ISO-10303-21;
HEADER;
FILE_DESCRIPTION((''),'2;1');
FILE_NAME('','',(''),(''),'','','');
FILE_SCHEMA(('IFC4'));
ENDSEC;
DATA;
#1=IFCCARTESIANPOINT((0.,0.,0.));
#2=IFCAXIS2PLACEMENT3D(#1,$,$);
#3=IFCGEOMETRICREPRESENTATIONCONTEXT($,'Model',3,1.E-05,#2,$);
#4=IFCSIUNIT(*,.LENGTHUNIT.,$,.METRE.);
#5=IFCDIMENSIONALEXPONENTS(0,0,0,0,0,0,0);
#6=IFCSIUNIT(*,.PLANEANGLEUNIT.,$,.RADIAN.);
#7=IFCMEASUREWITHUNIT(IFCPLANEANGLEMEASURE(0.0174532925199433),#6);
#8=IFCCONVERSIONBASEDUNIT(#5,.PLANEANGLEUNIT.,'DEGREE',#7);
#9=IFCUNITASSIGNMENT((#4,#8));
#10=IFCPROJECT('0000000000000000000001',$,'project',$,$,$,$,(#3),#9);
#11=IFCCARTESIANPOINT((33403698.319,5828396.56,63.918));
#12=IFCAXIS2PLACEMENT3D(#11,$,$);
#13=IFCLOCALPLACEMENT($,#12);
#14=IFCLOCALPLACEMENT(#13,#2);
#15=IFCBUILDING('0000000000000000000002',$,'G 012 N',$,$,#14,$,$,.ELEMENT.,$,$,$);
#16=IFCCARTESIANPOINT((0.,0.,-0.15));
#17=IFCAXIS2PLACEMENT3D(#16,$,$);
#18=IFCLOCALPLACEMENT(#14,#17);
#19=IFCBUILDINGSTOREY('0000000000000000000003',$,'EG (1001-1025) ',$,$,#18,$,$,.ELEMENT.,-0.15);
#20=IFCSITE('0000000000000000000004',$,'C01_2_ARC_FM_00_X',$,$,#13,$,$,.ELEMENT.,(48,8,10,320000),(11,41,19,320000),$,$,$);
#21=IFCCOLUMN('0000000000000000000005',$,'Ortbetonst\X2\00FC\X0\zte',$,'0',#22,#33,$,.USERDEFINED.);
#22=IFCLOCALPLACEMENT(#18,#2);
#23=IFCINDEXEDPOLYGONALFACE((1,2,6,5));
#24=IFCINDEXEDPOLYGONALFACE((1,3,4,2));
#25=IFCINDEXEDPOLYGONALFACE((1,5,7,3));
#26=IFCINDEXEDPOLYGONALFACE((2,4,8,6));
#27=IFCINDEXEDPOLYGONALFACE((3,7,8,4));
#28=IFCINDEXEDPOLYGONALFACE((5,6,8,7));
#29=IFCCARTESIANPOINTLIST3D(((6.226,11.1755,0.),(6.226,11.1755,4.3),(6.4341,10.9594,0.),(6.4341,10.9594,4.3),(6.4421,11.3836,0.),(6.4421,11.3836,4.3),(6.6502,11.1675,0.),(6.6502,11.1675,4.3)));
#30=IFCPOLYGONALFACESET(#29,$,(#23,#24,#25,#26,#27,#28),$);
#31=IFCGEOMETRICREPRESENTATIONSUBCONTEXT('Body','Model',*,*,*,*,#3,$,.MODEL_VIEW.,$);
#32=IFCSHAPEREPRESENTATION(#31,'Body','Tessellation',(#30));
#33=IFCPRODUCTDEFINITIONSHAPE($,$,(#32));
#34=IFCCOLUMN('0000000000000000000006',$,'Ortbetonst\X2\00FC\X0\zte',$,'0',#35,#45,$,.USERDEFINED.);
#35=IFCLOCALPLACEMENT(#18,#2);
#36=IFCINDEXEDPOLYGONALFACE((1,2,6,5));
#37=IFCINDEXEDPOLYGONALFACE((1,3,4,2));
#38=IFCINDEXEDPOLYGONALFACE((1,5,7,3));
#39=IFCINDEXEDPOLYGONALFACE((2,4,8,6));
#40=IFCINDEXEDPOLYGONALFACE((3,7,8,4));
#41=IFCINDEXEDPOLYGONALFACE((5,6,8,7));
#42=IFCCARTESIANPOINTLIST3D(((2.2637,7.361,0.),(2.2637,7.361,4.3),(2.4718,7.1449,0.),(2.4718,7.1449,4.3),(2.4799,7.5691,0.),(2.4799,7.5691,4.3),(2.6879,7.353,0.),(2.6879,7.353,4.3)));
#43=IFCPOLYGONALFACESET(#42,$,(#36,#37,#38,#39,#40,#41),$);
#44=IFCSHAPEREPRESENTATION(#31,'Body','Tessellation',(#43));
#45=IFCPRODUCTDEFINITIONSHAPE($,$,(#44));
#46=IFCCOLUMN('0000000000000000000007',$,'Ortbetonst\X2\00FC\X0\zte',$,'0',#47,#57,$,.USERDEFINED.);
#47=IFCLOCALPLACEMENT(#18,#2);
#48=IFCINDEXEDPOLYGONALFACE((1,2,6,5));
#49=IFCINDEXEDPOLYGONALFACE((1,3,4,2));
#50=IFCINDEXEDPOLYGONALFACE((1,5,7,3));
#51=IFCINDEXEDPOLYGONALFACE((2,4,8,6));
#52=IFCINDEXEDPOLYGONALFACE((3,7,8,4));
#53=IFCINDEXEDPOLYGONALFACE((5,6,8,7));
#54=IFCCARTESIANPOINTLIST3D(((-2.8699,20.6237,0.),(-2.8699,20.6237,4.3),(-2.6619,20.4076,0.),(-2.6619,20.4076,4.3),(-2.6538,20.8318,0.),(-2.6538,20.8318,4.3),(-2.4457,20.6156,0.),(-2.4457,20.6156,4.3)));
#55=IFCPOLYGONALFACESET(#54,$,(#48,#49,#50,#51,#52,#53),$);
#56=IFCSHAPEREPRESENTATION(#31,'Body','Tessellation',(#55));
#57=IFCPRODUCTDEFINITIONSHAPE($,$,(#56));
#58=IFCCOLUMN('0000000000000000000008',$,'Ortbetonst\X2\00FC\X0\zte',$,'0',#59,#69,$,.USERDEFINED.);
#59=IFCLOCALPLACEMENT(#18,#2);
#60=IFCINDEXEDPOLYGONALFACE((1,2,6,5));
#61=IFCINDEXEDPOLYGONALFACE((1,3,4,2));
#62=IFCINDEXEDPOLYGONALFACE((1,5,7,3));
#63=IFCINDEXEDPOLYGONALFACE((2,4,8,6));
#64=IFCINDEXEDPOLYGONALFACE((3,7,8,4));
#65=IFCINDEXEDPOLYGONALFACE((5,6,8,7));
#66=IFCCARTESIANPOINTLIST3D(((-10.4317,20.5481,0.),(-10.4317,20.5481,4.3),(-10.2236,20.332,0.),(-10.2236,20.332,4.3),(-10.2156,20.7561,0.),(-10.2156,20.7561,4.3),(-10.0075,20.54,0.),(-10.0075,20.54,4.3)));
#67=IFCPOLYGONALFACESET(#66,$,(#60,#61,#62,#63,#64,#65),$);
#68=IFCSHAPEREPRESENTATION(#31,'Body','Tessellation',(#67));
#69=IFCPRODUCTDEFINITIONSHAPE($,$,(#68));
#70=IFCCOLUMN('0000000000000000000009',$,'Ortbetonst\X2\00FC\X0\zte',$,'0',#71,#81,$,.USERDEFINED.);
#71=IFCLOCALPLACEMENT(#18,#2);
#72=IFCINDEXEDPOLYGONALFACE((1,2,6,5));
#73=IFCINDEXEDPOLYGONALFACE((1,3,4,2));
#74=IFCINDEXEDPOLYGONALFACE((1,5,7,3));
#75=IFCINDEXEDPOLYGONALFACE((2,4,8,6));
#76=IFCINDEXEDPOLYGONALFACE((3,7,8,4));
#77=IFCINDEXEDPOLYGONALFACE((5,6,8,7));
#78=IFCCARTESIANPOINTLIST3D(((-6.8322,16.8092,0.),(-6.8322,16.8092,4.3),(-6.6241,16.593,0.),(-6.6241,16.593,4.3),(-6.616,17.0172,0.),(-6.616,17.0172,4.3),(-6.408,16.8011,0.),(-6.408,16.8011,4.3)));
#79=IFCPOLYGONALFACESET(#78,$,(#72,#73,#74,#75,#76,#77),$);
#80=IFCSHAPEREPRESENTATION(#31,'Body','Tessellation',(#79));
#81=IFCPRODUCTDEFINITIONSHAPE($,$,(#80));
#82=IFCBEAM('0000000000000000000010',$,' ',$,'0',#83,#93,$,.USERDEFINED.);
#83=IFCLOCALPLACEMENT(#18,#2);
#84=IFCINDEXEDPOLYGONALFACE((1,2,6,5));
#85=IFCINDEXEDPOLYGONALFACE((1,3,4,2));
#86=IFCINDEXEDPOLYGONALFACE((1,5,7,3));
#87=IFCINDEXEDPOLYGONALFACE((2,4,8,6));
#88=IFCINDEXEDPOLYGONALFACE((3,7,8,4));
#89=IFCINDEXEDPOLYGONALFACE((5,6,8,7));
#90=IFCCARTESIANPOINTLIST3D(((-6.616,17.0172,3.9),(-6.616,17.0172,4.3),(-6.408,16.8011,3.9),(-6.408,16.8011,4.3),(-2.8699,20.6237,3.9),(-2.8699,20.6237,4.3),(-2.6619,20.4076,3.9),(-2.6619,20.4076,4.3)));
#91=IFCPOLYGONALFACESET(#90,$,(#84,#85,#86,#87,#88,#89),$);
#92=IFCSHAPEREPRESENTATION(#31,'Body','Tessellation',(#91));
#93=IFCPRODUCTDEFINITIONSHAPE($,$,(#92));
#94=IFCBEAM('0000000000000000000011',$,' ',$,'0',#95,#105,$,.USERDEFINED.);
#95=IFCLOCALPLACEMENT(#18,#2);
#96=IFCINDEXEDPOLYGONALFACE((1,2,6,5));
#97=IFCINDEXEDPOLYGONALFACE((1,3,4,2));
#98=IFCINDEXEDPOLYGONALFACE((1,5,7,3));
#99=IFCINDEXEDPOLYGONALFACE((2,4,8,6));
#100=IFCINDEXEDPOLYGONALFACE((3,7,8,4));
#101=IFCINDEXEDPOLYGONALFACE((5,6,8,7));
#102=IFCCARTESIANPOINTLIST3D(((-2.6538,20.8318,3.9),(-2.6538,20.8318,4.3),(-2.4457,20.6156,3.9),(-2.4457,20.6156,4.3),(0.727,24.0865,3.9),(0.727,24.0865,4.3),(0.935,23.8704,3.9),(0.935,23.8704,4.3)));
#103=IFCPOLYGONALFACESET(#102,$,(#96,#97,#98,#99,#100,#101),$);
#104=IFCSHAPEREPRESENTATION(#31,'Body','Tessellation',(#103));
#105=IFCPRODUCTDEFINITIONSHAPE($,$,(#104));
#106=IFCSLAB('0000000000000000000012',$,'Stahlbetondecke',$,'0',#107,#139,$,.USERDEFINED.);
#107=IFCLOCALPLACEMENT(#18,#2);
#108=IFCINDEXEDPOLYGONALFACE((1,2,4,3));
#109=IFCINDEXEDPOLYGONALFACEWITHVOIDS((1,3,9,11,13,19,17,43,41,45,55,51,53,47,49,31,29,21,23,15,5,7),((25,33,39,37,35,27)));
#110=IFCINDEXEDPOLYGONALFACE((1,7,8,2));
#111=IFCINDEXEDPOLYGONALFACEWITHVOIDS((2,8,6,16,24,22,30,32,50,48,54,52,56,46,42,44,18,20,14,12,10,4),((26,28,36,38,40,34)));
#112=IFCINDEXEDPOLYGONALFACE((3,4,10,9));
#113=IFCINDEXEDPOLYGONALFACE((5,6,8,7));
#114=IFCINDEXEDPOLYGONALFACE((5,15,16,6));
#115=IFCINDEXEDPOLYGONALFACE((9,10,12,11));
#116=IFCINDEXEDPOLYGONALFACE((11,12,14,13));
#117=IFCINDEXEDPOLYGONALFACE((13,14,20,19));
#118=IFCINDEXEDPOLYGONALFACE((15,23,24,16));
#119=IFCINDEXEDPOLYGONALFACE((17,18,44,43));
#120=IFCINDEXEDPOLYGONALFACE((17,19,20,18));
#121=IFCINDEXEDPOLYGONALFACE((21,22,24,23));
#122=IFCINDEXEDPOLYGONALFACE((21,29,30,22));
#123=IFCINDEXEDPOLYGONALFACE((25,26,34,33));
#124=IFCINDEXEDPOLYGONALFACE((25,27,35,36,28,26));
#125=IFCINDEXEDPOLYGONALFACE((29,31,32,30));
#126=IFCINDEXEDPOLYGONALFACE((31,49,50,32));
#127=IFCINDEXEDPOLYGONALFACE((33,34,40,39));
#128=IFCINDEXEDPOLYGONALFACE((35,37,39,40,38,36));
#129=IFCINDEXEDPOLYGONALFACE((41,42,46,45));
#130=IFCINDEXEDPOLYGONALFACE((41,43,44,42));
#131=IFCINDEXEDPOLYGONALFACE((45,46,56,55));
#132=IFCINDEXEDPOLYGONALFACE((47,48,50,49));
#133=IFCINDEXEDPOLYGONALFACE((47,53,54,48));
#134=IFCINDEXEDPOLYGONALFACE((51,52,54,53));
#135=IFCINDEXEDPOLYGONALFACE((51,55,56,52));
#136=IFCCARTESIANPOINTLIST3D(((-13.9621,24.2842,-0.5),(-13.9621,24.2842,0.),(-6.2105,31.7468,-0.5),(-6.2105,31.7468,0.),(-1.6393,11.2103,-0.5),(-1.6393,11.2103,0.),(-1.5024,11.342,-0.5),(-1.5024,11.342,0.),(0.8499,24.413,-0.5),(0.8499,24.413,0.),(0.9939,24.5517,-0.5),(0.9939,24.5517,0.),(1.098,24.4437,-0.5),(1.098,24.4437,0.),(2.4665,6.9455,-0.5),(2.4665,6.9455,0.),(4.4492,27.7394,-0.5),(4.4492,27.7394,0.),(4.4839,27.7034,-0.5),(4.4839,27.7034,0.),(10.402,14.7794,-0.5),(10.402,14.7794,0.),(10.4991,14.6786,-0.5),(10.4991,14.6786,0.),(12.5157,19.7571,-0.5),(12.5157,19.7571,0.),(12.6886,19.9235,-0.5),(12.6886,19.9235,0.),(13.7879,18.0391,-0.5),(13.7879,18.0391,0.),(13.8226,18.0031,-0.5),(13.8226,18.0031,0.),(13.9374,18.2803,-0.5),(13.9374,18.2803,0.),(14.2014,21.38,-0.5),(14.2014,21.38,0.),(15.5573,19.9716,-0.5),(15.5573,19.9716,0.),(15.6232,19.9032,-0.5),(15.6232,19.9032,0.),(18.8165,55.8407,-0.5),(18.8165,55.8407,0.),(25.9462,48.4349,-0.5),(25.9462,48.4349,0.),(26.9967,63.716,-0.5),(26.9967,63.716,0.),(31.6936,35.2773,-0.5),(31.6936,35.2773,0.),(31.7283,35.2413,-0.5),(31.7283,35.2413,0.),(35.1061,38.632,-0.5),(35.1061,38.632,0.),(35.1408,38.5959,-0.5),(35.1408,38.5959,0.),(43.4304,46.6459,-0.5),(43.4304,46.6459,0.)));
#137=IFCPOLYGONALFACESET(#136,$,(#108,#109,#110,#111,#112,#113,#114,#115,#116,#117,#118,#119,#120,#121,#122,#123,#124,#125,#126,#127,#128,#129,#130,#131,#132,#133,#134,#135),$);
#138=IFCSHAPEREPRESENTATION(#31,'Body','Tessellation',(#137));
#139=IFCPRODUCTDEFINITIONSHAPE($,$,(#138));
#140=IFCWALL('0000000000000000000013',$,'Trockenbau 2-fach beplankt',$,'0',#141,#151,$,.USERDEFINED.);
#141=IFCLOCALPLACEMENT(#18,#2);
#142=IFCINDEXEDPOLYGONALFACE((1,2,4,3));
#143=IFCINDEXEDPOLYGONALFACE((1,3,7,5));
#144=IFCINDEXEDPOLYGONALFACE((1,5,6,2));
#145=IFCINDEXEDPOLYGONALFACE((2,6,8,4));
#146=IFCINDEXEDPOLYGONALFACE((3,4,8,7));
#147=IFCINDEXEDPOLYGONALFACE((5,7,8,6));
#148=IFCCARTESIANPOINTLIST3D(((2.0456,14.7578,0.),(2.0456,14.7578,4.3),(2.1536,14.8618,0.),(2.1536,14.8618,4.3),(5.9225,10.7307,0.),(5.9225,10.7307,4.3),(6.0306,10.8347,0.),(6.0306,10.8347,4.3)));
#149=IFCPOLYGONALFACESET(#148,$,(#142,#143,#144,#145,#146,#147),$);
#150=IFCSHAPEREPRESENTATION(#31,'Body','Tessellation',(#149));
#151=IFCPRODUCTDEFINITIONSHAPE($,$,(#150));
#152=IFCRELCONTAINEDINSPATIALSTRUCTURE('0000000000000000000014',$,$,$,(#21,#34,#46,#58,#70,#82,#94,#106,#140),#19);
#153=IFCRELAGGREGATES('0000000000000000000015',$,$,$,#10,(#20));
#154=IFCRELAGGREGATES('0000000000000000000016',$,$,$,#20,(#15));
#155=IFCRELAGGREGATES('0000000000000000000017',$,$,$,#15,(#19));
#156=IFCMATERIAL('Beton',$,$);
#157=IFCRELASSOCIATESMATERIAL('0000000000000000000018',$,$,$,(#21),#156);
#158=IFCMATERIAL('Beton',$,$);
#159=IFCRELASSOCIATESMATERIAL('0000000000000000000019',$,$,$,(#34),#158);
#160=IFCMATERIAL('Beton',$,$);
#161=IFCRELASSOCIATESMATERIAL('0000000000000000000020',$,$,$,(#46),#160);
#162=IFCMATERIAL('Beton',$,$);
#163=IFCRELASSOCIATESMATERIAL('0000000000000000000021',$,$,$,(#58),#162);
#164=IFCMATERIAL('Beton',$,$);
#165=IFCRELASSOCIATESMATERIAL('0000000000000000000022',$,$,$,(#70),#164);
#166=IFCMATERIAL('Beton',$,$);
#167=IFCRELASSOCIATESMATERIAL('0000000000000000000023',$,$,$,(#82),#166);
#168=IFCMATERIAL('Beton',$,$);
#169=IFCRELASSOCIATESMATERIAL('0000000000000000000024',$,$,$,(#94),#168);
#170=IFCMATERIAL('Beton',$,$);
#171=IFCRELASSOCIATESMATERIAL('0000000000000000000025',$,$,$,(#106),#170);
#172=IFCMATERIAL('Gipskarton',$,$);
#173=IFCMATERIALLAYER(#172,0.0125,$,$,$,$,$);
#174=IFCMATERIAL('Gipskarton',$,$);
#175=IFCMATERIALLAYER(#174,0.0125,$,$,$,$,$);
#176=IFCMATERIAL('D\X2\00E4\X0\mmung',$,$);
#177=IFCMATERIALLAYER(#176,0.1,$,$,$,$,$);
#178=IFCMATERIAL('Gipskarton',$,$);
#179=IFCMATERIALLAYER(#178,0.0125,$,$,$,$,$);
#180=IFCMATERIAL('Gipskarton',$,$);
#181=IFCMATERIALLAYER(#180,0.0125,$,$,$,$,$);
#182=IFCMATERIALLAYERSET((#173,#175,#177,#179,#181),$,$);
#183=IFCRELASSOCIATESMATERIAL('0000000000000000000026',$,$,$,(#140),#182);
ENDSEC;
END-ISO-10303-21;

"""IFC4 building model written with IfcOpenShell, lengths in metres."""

from ifc_helpers import new_model, entity, si_unit, converted_unit, frame, frame_2d, origin, origin_with_axes, place, context, subcontext, project, spatial, polyline, rectangle, outline, extrude, material, layer, layer_set, layer_usage, element, save


model = new_model("IFC4")

# Units and contexts
model_context = context("Model", 3, precision=1e-05, world=origin())
body_context = subcontext(model_context, "Body", "Model", "MODEL_VIEW")
ifc_project = project(units=[si_unit("LENGTHUNIT", "METRE"), converted_unit("PLANEANGLEUNIT", "DEGREE", entity("IfcPlaneAngleMeasure", 0.0174532925199433), si_unit("PLANEANGLEUNIT", "RADIAN"), dimensions=[0, 0, 0, 0, 0, 0, 0])], contexts=[model_context])

# Site, building, storey
site_placement = place(None, frame((33403698.319, 5828396.56, 63.918)))
site = spatial("IfcSite", under=ifc_project, at=site_placement, Name="C01_2_ARC_FM_00_X", CompositionType="ELEMENT", RefLatitude=(48, 8, 10, 320000), RefLongitude=(11, 41, 19, 320000))
building_placement = place(site_placement, origin())
building = spatial("IfcBuilding", under=site, at=building_placement, Name="G 012 N", CompositionType="ELEMENT")
storey_placement = place(building_placement, frame((0.0, 0.0, -0.15)))
storey = spatial("IfcBuildingStorey", under=building, at=storey_placement, Name="EG (1001-1025) ", CompositionType="ELEMENT", Elevation=-0.15)

# Columns
ifc_material_1 = material(Name="Beton")
column_1_placement = place(storey_placement, frame((6.4341, 10.9594, 0.0)))
element("IfcColumn", 1, at=column_1_placement, inside=storey, material=ifc_material_1, Name="Ortbetonstüzte", ObjectType="0", PredefinedType="USERDEFINED", context=body_context, shape_type="SweptSolid", body=[
    extrude(rectangle(XDim=0.3, YDim=0.3, at=frame_2d((0.004, 0.2121), x_axis=(0.720408, 0.693551))), origin_with_axes(), (0.0, 0.0, 1.0), 4.3),
])
ifc_material_2 = material(Name="Beton")
column_2_placement = place(storey_placement, frame((2.4718, 7.1449, 0.0)))
element("IfcColumn", 2, at=column_2_placement, inside=storey, material=ifc_material_2, Name="Ortbetonstüzte", ObjectType="0", PredefinedType="USERDEFINED", context=body_context, shape_type="SweptSolid", body=[
    extrude(rectangle(XDim=0.3, YDim=0.3, at=frame_2d((0.004, 0.2121), x_axis=(0.720408, 0.693551))), origin_with_axes(), (0.0, 0.0, 1.0), 4.3),
])
ifc_material_3 = material(Name="Beton")
column_3_placement = place(storey_placement, frame((-2.6619, 20.4076, 0.0)))
element("IfcColumn", 3, at=column_3_placement, inside=storey, material=ifc_material_3, Name="Ortbetonstüzte", ObjectType="0", PredefinedType="USERDEFINED", context=body_context, shape_type="SweptSolid", body=[
    extrude(rectangle(XDim=0.3, YDim=0.3, at=frame_2d((0.004, 0.2121), x_axis=(0.720408, 0.693551))), origin_with_axes(), (0.0, 0.0, 1.0), 4.3),
])
ifc_material_4 = material(Name="Beton")
column_4_placement = place(storey_placement, frame((-10.2236, 20.332, 0.0)))
element("IfcColumn", 4, at=column_4_placement, inside=storey, material=ifc_material_4, Name="Ortbetonstüzte", ObjectType="0", PredefinedType="USERDEFINED", context=body_context, shape_type="SweptSolid", body=[
    extrude(rectangle(XDim=0.3, YDim=0.3, at=frame_2d((0.004, 0.2121), x_axis=(0.720408, 0.693551))), origin_with_axes(), (0.0, 0.0, 1.0), 4.3),
])
ifc_material_5 = material(Name="Beton")
column_5_placement = place(storey_placement, frame((-6.6241, 16.593, 0.0)))
element("IfcColumn", 5, at=column_5_placement, inside=storey, material=ifc_material_5, Name="Ortbetonstüzte", ObjectType="0", PredefinedType="USERDEFINED", context=body_context, shape_type="SweptSolid", body=[
    extrude(rectangle(XDim=0.3, YDim=0.3, at=frame_2d((0.004, 0.2121), x_axis=(0.720408, 0.693551))), origin_with_axes(), (0.0, 0.0, 1.0), 4.3),
])

# Beams
ifc_material_6 = material(Name="Beton")
beam_1_placement = place(storey_placement, frame((-6.408, 16.8011, 3.9), z_axis=(0.0, 0.0, 1.0), x_axis=(0.720408, 0.693551, 0.0)))
element("IfcBeam", 6, at=beam_1_placement, inside=storey, material=ifc_material_6, Name=" ", ObjectType="0", PredefinedType="USERDEFINED", context=body_context, shape_type="SweptSolid", body=[
    extrude(rectangle(XDim=0.3, YDim=0.4, at=frame_2d((0.15, 0.2), x_axis=(1.0, 0.0))), frame((0.0, 0.0, 0.0), z_axis=(1.0, 0.0, 0.0), x_axis=(0.0, 1.0, 0.0)), (0.0, 0.0, 1.0), 5.2),
])
ifc_material_7 = material(Name="Beton")
beam_2_placement = place(storey_placement, frame((-2.4457, 20.6156, 3.9), z_axis=(0.0, 0.0, 1.0), x_axis=(0.720408, 0.693551, 0.0)))
element("IfcBeam", 7, at=beam_2_placement, inside=storey, material=ifc_material_7, Name=" ", ObjectType="0", PredefinedType="USERDEFINED", context=body_context, shape_type="SweptSolid", body=[
    extrude(rectangle(XDim=0.3, YDim=0.4, at=frame_2d((0.15, 0.2), x_axis=(1.0, 0.0))), frame((0.0, 0.0, 0.0), z_axis=(1.0, 0.0, 0.0), x_axis=(0.0, 1.0, 0.0)), (0.0, 0.0, 1.0), 4.6929),
])

# Slab, opening
ifc_material_8 = material(Name="Beton")
slab_placement = place(storey_placement, frame((-13.9621, 6.9455, -0.5)))
slab = element("IfcSlab", 8, at=slab_placement, inside=storey, material=ifc_material_8, Name="Stahlbetondecke", ObjectType="0", PredefinedType="USERDEFINED", context=body_context, shape_type="SweptSolid", body=[
    extrude(outline(polyline([(15.06, 17.4982), (14.956, 17.6063), (14.8119, 17.4676), (7.7516, 24.8013), (0.0, 17.3387), (12.4596, 4.3966), (12.3228, 4.2648), (16.4286, 0.0), (24.4611, 7.7331), (24.364, 7.8339), (27.7499, 11.0936), (27.7846, 11.0576), (45.6904, 28.2958), (45.6557, 28.3318), (49.1028, 31.6505), (49.0682, 31.6865), (57.3925, 39.7005), (40.9588, 56.7705), (32.7786, 48.8953), (39.9083, 41.4895), (18.4113, 20.7939), (18.446, 20.7579), (15.06, 17.4982)]), holes=[polyline([(26.6506, 12.9781), (28.1635, 14.4345), (29.5194, 13.0261), (28.0065, 11.5697), (26.6506, 12.9781)])]), origin_with_axes(), (0.0, 0.0, 1.0), 0.5),
])
opening_1_placement = place(slab_placement, frame((26.4777, 11.3348, 0.0)))
element("IfcOpeningElement", 9, at=opening_1_placement, cuts=slab, ObjectType="Opening", context=body_context, shape_type="SweptSolid", body=[
    extrude(rectangle(XDim=2.05, YDim=2.34, at=frame_2d((0.0, 0.0), x_axis=(-0.693551, 0.720408))), frame((1.5538, 1.5499, 0.0), z_axis=(0.0, 0.0, 1.0), x_axis=(1.0, 0.0, 0.0)), (0.0, 0.0, 1.0), 0.5),
])

# Wall
ifc_material_9 = material(Name="Gipskarton")
ifc_layer_1 = layer(ifc_material_9, 0.0125)
ifc_material_10 = material(Name="Gipskarton")
ifc_layer_2 = layer(ifc_material_10, 0.0125)
ifc_material_11 = material(Name="Dämmung")
ifc_layer_3 = layer(ifc_material_11, 0.1)
ifc_material_12 = material(Name="Gipskarton")
ifc_layer_4 = layer(ifc_material_12, 0.0125)
ifc_material_13 = material(Name="Gipskarton")
ifc_layer_5 = layer(ifc_material_13, 0.0125)
ifc_layer_set_1 = layer_set([ifc_layer_1, ifc_layer_2, ifc_layer_3, ifc_layer_4, ifc_layer_5])
ifc_layer_usage_1 = layer_usage(ifc_layer_set_1, "AXIS2", "POSITIVE", 0.0)
wall_1_placement = place(storey_placement, frame((2.0456, 14.7578, 0.0), z_axis=(0.0, 0.0, 1.0), x_axis=(0.693551, -0.720408, 0.0)))
element("IfcWall", 10, at=wall_1_placement, inside=storey, material=ifc_layer_usage_1, Name="Trockenbau 2-fach beplankt", ObjectType="0", PredefinedType="USERDEFINED", context=body_context, shape_type="SweptSolid", body=[
    extrude(rectangle(XDim=5.59, YDim=0.15, at=frame_2d((2.795, 0.075), x_axis=(1.0, 0.0))), origin_with_axes(), (0.0, 0.0, 1.0), 4.3),
])

save(model, "model.ifc")
